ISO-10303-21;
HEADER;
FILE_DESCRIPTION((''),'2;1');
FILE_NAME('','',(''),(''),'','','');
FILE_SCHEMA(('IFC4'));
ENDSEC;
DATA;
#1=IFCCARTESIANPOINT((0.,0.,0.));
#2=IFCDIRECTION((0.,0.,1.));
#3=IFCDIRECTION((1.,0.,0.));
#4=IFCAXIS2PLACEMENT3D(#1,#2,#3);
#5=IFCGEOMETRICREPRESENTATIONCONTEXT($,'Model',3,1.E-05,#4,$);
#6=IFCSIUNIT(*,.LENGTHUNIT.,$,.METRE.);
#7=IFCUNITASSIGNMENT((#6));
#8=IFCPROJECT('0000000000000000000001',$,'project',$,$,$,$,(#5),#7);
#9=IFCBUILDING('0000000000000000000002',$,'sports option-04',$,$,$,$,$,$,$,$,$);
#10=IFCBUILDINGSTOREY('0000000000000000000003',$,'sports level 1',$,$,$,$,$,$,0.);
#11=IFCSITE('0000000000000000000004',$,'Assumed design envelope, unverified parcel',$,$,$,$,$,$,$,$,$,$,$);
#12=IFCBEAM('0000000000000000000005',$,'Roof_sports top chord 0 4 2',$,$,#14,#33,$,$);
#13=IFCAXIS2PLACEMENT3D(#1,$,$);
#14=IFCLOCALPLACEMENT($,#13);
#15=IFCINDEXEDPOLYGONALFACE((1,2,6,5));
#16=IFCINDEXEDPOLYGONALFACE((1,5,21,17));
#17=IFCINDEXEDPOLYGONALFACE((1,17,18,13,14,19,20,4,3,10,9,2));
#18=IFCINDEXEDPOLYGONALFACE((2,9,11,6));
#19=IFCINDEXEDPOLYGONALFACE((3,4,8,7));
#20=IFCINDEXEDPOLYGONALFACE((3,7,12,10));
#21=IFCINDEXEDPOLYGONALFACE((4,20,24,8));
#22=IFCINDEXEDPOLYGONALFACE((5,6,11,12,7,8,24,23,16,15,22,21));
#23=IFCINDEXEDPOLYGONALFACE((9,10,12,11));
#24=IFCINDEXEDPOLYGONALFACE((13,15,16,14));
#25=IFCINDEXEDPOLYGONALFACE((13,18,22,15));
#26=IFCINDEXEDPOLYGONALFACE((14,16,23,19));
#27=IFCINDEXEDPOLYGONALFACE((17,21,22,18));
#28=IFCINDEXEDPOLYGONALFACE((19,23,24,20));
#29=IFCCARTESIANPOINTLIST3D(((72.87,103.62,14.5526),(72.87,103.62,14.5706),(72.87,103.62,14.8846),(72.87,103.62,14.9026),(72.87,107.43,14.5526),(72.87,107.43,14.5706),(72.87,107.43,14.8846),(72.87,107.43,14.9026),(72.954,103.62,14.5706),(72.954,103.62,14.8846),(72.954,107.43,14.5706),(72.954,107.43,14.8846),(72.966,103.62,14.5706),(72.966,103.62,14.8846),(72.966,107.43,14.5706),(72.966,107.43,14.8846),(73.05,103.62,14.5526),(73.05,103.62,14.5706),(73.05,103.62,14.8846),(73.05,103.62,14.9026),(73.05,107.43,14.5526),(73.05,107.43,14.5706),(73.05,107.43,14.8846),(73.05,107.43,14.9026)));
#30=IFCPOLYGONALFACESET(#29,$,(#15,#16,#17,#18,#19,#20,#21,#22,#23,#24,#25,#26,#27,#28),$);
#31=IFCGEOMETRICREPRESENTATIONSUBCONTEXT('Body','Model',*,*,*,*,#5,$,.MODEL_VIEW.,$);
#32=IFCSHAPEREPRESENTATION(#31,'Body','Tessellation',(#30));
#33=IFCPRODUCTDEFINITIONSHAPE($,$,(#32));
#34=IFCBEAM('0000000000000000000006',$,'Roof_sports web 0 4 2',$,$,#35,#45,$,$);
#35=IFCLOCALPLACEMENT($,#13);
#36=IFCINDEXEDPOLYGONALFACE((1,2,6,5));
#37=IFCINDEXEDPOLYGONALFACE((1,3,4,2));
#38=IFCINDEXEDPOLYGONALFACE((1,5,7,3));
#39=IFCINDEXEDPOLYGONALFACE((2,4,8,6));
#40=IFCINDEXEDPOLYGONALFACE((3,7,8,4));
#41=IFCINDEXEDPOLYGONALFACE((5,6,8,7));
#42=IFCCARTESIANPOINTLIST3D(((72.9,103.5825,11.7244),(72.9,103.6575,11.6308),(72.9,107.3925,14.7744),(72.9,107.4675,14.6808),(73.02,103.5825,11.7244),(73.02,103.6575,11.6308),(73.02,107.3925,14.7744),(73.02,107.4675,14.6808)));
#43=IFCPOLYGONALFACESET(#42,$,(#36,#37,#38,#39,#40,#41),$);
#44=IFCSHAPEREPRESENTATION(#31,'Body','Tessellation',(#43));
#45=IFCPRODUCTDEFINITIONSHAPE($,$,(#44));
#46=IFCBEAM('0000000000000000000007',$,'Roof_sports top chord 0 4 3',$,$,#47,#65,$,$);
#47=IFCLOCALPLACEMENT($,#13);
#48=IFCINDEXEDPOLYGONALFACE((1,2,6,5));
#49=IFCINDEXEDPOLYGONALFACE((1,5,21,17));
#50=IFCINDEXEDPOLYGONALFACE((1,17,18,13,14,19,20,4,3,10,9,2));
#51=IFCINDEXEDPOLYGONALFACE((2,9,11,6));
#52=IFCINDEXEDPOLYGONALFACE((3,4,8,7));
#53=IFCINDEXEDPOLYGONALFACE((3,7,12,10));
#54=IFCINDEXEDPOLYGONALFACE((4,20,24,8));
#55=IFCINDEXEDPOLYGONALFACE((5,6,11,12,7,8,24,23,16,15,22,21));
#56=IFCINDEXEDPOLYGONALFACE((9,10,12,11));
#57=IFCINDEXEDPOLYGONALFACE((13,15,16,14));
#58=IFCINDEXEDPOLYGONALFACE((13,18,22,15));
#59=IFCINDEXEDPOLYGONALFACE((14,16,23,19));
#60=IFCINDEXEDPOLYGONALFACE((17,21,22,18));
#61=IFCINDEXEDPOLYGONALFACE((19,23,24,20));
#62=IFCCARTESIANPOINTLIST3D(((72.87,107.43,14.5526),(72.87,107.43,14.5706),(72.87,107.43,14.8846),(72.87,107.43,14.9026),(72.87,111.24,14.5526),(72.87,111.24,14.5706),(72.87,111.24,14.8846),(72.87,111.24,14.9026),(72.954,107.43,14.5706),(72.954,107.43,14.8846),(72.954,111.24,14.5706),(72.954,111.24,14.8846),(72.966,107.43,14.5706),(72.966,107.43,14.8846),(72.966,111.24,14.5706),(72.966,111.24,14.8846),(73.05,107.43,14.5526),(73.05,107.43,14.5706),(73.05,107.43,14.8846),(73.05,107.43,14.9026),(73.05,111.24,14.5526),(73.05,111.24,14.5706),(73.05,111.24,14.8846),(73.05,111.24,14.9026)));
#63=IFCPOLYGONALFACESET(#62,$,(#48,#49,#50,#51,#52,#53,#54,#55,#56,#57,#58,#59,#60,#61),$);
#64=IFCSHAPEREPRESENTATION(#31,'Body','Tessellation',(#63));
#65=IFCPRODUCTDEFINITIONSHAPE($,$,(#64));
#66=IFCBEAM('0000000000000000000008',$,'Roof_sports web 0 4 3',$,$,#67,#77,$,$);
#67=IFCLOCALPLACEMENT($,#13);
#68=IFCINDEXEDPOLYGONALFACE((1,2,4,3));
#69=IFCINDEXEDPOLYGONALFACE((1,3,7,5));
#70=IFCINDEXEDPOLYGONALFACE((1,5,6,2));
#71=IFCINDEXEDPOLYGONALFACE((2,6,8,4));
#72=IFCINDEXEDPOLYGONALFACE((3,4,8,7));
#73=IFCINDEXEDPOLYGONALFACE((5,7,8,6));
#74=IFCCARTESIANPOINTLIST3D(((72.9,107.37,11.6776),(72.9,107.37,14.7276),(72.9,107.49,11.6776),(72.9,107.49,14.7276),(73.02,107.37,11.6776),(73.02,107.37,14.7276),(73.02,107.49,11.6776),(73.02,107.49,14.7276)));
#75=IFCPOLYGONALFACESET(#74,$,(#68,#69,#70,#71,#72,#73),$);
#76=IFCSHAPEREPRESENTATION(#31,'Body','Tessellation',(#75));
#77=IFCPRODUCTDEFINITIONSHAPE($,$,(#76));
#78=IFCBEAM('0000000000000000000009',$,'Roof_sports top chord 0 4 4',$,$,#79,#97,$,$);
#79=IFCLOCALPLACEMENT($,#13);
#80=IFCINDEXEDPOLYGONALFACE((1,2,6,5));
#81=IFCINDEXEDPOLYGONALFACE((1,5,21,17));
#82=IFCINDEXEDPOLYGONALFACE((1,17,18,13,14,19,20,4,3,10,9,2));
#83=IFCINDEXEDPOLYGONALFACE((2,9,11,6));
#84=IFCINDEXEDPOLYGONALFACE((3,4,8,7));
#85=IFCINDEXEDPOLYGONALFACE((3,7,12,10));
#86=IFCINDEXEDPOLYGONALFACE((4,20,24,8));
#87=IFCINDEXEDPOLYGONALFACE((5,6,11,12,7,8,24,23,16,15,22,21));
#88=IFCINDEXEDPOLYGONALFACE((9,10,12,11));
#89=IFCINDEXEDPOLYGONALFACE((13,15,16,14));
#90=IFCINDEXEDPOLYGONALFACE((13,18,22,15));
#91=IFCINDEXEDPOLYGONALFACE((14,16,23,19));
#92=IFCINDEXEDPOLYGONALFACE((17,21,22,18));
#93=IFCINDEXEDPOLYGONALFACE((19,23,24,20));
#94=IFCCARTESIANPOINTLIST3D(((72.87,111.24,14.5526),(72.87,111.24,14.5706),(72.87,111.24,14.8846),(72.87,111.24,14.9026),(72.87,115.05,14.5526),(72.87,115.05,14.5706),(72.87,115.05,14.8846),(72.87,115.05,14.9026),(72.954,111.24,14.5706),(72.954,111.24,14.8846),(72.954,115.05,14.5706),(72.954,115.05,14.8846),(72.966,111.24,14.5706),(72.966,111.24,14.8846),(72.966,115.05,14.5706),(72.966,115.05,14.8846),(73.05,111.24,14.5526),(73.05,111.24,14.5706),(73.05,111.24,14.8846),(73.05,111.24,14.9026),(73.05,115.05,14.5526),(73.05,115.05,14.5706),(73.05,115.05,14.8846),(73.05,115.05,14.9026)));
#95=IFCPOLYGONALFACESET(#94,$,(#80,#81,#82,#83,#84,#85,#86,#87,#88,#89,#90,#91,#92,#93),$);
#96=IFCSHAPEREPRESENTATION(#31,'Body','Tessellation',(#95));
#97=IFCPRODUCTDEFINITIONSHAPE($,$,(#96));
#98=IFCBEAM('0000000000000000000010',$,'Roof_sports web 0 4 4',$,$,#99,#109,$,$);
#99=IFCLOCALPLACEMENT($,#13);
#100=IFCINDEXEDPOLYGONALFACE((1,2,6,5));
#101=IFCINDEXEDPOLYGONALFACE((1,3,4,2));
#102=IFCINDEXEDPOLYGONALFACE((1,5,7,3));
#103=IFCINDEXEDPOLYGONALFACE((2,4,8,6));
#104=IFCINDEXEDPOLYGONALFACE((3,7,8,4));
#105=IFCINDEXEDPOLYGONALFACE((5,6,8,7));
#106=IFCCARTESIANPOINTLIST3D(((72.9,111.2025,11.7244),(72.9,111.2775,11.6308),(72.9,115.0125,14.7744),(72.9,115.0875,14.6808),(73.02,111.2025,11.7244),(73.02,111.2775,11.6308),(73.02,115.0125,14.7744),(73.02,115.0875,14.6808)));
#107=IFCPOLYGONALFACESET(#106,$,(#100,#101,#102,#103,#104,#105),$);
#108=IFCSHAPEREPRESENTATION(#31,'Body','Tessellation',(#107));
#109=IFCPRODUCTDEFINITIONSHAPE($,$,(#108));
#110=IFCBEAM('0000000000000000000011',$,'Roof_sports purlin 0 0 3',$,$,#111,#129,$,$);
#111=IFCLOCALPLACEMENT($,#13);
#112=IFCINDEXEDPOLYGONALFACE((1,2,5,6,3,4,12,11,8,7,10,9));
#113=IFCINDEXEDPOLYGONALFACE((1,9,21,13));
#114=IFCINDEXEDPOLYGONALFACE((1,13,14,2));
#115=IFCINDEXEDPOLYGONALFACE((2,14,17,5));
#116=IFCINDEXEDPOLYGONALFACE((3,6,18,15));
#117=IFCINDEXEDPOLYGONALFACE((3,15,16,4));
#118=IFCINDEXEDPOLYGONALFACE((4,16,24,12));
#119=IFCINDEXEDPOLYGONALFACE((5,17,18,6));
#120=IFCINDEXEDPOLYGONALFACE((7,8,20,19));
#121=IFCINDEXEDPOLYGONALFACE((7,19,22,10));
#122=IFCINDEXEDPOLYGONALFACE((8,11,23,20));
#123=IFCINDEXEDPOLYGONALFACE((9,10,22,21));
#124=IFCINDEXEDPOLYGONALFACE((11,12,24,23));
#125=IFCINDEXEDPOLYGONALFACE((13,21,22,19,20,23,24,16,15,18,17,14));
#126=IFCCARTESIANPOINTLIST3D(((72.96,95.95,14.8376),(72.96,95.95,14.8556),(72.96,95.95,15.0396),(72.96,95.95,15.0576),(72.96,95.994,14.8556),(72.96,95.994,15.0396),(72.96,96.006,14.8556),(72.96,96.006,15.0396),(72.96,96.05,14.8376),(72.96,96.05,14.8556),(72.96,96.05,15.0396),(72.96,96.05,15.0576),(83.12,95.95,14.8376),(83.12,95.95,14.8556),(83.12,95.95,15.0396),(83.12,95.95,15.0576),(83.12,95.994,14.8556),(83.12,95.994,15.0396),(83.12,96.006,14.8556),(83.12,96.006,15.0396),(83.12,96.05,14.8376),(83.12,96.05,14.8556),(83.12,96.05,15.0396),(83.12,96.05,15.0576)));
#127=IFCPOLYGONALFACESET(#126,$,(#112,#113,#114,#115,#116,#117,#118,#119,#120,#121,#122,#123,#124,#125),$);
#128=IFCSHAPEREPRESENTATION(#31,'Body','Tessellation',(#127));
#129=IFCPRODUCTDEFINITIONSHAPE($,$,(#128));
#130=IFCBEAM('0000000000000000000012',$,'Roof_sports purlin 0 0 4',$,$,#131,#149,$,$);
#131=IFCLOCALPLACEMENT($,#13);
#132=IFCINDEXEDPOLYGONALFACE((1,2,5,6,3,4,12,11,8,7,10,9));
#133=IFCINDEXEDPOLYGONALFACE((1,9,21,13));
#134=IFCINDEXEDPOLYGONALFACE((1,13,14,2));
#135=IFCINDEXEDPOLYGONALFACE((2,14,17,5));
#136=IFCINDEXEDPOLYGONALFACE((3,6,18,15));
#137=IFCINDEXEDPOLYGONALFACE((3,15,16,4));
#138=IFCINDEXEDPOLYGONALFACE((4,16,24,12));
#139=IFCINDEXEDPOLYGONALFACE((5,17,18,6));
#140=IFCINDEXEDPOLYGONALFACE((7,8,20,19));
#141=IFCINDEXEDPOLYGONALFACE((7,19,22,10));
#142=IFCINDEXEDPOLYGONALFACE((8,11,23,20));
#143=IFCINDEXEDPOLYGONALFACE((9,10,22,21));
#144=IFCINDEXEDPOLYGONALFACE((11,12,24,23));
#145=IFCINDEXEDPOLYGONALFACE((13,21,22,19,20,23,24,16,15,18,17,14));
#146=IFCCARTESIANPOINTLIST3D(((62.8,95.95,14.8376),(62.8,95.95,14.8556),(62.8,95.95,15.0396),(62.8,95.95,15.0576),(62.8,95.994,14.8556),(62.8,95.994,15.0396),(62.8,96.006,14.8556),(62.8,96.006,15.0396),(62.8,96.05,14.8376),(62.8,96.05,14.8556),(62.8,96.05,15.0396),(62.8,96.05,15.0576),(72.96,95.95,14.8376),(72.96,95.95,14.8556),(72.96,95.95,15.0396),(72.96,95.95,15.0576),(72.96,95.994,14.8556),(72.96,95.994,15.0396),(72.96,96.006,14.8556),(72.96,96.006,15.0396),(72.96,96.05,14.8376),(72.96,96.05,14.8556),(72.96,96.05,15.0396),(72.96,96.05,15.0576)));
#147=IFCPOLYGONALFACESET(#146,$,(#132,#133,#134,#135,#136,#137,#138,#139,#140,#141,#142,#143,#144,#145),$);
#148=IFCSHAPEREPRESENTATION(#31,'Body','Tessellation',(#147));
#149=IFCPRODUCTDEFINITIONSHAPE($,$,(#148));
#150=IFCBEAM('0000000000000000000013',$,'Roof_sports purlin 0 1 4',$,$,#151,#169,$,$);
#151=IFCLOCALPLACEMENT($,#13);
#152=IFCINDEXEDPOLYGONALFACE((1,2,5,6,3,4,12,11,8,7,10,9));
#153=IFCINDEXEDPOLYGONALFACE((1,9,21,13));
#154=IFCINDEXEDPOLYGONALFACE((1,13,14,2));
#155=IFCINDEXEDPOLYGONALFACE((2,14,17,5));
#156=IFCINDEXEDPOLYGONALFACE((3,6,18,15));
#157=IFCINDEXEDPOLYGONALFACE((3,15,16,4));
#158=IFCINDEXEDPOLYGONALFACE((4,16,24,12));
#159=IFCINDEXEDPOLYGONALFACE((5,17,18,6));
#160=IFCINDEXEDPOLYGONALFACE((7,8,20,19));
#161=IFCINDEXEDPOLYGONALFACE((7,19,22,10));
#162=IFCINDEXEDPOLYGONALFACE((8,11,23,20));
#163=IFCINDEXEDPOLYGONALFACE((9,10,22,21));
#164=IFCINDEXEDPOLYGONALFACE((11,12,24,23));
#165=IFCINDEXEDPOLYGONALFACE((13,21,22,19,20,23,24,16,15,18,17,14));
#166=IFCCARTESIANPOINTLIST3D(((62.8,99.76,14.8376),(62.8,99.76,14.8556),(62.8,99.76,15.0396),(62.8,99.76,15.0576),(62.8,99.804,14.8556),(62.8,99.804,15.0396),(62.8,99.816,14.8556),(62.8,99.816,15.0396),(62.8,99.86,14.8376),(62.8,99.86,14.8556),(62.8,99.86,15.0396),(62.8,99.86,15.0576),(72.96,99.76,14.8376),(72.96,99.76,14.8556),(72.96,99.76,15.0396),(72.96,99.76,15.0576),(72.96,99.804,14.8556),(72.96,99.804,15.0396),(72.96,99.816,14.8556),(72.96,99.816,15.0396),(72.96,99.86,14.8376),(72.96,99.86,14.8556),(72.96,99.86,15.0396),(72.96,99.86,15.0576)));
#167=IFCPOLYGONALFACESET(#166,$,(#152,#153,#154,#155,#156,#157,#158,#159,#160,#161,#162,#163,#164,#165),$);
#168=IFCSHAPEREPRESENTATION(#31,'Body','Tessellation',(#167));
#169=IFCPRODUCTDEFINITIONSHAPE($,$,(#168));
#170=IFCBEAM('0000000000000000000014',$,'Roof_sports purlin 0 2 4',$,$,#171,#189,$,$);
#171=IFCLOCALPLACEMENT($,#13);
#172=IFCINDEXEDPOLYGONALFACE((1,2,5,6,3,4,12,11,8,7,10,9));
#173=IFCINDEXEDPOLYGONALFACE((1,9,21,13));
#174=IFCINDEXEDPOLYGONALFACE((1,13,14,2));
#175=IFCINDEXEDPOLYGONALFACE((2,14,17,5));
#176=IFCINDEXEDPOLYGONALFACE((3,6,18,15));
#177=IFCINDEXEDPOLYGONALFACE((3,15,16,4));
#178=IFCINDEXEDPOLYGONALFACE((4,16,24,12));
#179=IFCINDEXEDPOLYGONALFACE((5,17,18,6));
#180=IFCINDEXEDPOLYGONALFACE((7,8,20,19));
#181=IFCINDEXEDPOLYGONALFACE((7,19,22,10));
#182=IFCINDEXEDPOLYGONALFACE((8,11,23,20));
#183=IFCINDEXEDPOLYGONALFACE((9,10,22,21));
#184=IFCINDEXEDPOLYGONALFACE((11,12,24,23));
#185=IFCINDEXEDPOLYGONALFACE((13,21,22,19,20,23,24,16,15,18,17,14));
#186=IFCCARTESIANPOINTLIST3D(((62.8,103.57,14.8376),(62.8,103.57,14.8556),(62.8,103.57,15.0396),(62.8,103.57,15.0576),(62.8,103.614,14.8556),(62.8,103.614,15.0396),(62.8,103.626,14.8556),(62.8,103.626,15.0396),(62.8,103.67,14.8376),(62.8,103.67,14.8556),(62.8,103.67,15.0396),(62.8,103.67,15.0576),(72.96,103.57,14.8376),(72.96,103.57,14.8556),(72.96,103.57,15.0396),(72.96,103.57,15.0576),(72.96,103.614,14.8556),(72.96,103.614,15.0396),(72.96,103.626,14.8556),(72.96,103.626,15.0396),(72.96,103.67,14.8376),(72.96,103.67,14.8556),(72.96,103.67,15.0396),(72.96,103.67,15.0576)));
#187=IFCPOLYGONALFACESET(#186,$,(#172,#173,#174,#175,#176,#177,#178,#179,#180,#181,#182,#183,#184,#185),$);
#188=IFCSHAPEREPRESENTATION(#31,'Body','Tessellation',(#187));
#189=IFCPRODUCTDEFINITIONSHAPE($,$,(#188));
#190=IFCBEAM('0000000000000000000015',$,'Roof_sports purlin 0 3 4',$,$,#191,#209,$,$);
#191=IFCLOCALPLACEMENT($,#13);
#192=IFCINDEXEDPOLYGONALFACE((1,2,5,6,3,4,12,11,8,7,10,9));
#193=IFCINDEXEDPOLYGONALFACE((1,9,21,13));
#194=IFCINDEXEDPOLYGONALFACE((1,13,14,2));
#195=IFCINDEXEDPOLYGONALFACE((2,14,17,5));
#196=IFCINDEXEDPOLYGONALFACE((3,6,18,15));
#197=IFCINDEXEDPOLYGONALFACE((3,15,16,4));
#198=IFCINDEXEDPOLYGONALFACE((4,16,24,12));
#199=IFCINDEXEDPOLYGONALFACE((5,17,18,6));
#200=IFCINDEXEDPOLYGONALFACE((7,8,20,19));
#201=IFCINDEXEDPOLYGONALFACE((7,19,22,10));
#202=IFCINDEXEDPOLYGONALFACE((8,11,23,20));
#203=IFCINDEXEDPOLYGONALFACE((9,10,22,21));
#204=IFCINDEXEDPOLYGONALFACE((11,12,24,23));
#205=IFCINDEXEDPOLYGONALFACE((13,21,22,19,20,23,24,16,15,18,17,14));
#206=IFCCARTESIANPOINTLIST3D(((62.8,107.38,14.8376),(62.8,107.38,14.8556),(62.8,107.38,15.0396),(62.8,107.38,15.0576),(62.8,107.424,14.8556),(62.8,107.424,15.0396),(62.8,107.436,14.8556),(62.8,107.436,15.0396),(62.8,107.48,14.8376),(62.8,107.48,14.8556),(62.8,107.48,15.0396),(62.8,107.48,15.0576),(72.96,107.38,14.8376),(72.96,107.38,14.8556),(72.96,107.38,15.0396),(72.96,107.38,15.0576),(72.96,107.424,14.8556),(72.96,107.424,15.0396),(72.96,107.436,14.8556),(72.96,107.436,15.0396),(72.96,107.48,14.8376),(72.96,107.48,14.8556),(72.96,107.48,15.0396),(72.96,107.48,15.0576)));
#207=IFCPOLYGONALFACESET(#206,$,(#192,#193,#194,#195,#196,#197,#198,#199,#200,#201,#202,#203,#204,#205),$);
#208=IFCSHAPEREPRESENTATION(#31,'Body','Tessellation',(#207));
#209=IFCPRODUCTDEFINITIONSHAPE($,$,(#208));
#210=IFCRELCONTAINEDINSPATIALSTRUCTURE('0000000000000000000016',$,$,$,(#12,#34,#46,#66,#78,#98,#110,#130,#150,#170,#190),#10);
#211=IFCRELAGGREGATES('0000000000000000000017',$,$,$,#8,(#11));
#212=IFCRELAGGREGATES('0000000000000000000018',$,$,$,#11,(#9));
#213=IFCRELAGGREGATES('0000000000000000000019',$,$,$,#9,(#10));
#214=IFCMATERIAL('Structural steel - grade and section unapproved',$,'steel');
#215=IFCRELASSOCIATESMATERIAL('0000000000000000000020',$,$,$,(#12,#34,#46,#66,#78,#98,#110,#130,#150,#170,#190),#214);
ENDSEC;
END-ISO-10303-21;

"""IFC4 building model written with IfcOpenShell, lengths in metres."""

from ifc_helpers import new_model, si_unit, frame, origin_with_axes, place, context, subcontext, project, spatial, rectangle, i_section, extrude, material, element, save


model = new_model("IFC4")

# Units and contexts
model_context = context("Model", 3, precision=1e-05, world=origin_with_axes())
body_context = subcontext(model_context, "Body", "Model", "MODEL_VIEW")
ifc_project = project(units=[si_unit("LENGTHUNIT", "METRE")], contexts=[model_context])

# Site, building, storey
site = spatial("IfcSite", under=ifc_project, Name="Assumed design envelope, unverified parcel")
building = spatial("IfcBuilding", under=site, Name="sports option-04")
storey = spatial("IfcBuildingStorey", under=building, Name="sports level 1", Elevation=0.0)

# Shared definitions
ifc_material_1 = material(Name="Structural steel - grade and section unapproved", Category="steel")

# Beams
beam_1_placement = place(None, frame((72.96, 103.62, 14.7276), z_axis=(0.0, 1.0, 0.0), x_axis=(-1.0, 0.0, 0.0)))
element("IfcBeam", 1, at=beam_1_placement, inside=storey, material=ifc_material_1, Name="Roof_sports top chord 0 4 2", context=body_context, shape_type="SweptSolid", body=[
    extrude(i_section(OverallWidth=0.18, OverallDepth=0.35, WebThickness=0.012, FlangeThickness=0.018, FilletRadius=0.0), origin_with_axes(), (0.0, 0.0, 1.0), 3.81),
])
beam_2_placement = place(None, frame((72.96, 103.62, 11.6776), z_axis=(0.0, 0.780669, 0.624945), x_axis=(-1.0, 0.0, 0.0)))
element("IfcBeam", 2, at=beam_2_placement, inside=storey, material=ifc_material_1, Name="Roof_sports web 0 4 2", context=body_context, shape_type="SweptSolid", body=[
    extrude(rectangle(XDim=0.12, YDim=0.12), origin_with_axes(), (0.0, 0.0, 1.0), 4.8804),
])
beam_3_placement = place(None, frame((72.96, 107.43, 14.7276), z_axis=(0.0, 1.0, 0.0), x_axis=(-1.0, 0.0, 0.0)))
element("IfcBeam", 3, at=beam_3_placement, inside=storey, material=ifc_material_1, Name="Roof_sports top chord 0 4 3", context=body_context, shape_type="SweptSolid", body=[
    extrude(i_section(OverallWidth=0.18, OverallDepth=0.35, WebThickness=0.012, FlangeThickness=0.018, FilletRadius=0.0), origin_with_axes(), (0.0, 0.0, 1.0), 3.81),
])
beam_4_placement = place(None, frame((72.96, 107.43, 11.6776), z_axis=(0.0, 0.0, 1.0), x_axis=(-1.0, 0.0, 0.0)))
element("IfcBeam", 4, at=beam_4_placement, inside=storey, material=ifc_material_1, Name="Roof_sports web 0 4 3", context=body_context, shape_type="SweptSolid", body=[
    extrude(rectangle(XDim=0.12, YDim=0.12), origin_with_axes(), (0.0, 0.0, 1.0), 3.05),
])
beam_5_placement = place(None, frame((72.96, 111.24, 14.7276), z_axis=(0.0, 1.0, 0.0), x_axis=(-1.0, 0.0, 0.0)))
element("IfcBeam", 5, at=beam_5_placement, inside=storey, material=ifc_material_1, Name="Roof_sports top chord 0 4 4", context=body_context, shape_type="SweptSolid", body=[
    extrude(i_section(OverallWidth=0.18, OverallDepth=0.35, WebThickness=0.012, FlangeThickness=0.018, FilletRadius=0.0), origin_with_axes(), (0.0, 0.0, 1.0), 3.81),
])
beam_6_placement = place(None, frame((72.96, 111.24, 11.6776), z_axis=(0.0, 0.780669, 0.624944), x_axis=(-1.0, 0.0, 0.0)))
element("IfcBeam", 6, at=beam_6_placement, inside=storey, material=ifc_material_1, Name="Roof_sports web 0 4 4", context=body_context, shape_type="SweptSolid", body=[
    extrude(rectangle(XDim=0.12, YDim=0.12), origin_with_axes(), (0.0, 0.0, 1.0), 4.8804),
])
beam_7_placement = place(None, frame((83.12, 96.0, 14.9476), z_axis=(-1.0, 0.0, 0.0), x_axis=(0.0, -1.0, 0.0)))
element("IfcBeam", 7, at=beam_7_placement, inside=storey, material=ifc_material_1, Name="Roof_sports purlin 0 0 3", context=body_context, shape_type="SweptSolid", body=[
    extrude(i_section(OverallWidth=0.1, OverallDepth=0.22, WebThickness=0.012, FlangeThickness=0.018, FilletRadius=0.0), origin_with_axes(), (0.0, 0.0, 1.0), 10.16),
])
for number, where, z_axis, x_axis, name in (
    (8, (72.96, 96.0, 14.9476), (-1.0, 0.0, 0.0), (0.0, -1.0, 0.0), "Roof_sports purlin 0 0 4"),
    (9, (72.96, 99.81, 14.9476), (-1.0, 0.0, 0.0), (0.0, -1.0, 0.0), "Roof_sports purlin 0 1 4"),
    (10, (72.96, 103.62, 14.9476), (-1.0, 0.0, 0.0), (0.0, -1.0, 0.0), "Roof_sports purlin 0 2 4"),
    (11, (72.96, 107.43, 14.9476), (-1.0, 0.0, 0.0), (0.0, -1.0, 0.0), "Roof_sports purlin 0 3 4"),
):
    element("IfcBeam", number, at=place(None, frame(where, z_axis=z_axis, x_axis=x_axis)), inside=storey, material=ifc_material_1, Name=name, context=body_context, shape_type="SweptSolid", body=[
        extrude(i_section(OverallWidth=0.1, OverallDepth=0.22, WebThickness=0.012, FlangeThickness=0.018, FilletRadius=0.0), origin_with_axes(), (0.0, 0.0, 1.0), 10.16),
    ])

save(model, "model.ifc")
